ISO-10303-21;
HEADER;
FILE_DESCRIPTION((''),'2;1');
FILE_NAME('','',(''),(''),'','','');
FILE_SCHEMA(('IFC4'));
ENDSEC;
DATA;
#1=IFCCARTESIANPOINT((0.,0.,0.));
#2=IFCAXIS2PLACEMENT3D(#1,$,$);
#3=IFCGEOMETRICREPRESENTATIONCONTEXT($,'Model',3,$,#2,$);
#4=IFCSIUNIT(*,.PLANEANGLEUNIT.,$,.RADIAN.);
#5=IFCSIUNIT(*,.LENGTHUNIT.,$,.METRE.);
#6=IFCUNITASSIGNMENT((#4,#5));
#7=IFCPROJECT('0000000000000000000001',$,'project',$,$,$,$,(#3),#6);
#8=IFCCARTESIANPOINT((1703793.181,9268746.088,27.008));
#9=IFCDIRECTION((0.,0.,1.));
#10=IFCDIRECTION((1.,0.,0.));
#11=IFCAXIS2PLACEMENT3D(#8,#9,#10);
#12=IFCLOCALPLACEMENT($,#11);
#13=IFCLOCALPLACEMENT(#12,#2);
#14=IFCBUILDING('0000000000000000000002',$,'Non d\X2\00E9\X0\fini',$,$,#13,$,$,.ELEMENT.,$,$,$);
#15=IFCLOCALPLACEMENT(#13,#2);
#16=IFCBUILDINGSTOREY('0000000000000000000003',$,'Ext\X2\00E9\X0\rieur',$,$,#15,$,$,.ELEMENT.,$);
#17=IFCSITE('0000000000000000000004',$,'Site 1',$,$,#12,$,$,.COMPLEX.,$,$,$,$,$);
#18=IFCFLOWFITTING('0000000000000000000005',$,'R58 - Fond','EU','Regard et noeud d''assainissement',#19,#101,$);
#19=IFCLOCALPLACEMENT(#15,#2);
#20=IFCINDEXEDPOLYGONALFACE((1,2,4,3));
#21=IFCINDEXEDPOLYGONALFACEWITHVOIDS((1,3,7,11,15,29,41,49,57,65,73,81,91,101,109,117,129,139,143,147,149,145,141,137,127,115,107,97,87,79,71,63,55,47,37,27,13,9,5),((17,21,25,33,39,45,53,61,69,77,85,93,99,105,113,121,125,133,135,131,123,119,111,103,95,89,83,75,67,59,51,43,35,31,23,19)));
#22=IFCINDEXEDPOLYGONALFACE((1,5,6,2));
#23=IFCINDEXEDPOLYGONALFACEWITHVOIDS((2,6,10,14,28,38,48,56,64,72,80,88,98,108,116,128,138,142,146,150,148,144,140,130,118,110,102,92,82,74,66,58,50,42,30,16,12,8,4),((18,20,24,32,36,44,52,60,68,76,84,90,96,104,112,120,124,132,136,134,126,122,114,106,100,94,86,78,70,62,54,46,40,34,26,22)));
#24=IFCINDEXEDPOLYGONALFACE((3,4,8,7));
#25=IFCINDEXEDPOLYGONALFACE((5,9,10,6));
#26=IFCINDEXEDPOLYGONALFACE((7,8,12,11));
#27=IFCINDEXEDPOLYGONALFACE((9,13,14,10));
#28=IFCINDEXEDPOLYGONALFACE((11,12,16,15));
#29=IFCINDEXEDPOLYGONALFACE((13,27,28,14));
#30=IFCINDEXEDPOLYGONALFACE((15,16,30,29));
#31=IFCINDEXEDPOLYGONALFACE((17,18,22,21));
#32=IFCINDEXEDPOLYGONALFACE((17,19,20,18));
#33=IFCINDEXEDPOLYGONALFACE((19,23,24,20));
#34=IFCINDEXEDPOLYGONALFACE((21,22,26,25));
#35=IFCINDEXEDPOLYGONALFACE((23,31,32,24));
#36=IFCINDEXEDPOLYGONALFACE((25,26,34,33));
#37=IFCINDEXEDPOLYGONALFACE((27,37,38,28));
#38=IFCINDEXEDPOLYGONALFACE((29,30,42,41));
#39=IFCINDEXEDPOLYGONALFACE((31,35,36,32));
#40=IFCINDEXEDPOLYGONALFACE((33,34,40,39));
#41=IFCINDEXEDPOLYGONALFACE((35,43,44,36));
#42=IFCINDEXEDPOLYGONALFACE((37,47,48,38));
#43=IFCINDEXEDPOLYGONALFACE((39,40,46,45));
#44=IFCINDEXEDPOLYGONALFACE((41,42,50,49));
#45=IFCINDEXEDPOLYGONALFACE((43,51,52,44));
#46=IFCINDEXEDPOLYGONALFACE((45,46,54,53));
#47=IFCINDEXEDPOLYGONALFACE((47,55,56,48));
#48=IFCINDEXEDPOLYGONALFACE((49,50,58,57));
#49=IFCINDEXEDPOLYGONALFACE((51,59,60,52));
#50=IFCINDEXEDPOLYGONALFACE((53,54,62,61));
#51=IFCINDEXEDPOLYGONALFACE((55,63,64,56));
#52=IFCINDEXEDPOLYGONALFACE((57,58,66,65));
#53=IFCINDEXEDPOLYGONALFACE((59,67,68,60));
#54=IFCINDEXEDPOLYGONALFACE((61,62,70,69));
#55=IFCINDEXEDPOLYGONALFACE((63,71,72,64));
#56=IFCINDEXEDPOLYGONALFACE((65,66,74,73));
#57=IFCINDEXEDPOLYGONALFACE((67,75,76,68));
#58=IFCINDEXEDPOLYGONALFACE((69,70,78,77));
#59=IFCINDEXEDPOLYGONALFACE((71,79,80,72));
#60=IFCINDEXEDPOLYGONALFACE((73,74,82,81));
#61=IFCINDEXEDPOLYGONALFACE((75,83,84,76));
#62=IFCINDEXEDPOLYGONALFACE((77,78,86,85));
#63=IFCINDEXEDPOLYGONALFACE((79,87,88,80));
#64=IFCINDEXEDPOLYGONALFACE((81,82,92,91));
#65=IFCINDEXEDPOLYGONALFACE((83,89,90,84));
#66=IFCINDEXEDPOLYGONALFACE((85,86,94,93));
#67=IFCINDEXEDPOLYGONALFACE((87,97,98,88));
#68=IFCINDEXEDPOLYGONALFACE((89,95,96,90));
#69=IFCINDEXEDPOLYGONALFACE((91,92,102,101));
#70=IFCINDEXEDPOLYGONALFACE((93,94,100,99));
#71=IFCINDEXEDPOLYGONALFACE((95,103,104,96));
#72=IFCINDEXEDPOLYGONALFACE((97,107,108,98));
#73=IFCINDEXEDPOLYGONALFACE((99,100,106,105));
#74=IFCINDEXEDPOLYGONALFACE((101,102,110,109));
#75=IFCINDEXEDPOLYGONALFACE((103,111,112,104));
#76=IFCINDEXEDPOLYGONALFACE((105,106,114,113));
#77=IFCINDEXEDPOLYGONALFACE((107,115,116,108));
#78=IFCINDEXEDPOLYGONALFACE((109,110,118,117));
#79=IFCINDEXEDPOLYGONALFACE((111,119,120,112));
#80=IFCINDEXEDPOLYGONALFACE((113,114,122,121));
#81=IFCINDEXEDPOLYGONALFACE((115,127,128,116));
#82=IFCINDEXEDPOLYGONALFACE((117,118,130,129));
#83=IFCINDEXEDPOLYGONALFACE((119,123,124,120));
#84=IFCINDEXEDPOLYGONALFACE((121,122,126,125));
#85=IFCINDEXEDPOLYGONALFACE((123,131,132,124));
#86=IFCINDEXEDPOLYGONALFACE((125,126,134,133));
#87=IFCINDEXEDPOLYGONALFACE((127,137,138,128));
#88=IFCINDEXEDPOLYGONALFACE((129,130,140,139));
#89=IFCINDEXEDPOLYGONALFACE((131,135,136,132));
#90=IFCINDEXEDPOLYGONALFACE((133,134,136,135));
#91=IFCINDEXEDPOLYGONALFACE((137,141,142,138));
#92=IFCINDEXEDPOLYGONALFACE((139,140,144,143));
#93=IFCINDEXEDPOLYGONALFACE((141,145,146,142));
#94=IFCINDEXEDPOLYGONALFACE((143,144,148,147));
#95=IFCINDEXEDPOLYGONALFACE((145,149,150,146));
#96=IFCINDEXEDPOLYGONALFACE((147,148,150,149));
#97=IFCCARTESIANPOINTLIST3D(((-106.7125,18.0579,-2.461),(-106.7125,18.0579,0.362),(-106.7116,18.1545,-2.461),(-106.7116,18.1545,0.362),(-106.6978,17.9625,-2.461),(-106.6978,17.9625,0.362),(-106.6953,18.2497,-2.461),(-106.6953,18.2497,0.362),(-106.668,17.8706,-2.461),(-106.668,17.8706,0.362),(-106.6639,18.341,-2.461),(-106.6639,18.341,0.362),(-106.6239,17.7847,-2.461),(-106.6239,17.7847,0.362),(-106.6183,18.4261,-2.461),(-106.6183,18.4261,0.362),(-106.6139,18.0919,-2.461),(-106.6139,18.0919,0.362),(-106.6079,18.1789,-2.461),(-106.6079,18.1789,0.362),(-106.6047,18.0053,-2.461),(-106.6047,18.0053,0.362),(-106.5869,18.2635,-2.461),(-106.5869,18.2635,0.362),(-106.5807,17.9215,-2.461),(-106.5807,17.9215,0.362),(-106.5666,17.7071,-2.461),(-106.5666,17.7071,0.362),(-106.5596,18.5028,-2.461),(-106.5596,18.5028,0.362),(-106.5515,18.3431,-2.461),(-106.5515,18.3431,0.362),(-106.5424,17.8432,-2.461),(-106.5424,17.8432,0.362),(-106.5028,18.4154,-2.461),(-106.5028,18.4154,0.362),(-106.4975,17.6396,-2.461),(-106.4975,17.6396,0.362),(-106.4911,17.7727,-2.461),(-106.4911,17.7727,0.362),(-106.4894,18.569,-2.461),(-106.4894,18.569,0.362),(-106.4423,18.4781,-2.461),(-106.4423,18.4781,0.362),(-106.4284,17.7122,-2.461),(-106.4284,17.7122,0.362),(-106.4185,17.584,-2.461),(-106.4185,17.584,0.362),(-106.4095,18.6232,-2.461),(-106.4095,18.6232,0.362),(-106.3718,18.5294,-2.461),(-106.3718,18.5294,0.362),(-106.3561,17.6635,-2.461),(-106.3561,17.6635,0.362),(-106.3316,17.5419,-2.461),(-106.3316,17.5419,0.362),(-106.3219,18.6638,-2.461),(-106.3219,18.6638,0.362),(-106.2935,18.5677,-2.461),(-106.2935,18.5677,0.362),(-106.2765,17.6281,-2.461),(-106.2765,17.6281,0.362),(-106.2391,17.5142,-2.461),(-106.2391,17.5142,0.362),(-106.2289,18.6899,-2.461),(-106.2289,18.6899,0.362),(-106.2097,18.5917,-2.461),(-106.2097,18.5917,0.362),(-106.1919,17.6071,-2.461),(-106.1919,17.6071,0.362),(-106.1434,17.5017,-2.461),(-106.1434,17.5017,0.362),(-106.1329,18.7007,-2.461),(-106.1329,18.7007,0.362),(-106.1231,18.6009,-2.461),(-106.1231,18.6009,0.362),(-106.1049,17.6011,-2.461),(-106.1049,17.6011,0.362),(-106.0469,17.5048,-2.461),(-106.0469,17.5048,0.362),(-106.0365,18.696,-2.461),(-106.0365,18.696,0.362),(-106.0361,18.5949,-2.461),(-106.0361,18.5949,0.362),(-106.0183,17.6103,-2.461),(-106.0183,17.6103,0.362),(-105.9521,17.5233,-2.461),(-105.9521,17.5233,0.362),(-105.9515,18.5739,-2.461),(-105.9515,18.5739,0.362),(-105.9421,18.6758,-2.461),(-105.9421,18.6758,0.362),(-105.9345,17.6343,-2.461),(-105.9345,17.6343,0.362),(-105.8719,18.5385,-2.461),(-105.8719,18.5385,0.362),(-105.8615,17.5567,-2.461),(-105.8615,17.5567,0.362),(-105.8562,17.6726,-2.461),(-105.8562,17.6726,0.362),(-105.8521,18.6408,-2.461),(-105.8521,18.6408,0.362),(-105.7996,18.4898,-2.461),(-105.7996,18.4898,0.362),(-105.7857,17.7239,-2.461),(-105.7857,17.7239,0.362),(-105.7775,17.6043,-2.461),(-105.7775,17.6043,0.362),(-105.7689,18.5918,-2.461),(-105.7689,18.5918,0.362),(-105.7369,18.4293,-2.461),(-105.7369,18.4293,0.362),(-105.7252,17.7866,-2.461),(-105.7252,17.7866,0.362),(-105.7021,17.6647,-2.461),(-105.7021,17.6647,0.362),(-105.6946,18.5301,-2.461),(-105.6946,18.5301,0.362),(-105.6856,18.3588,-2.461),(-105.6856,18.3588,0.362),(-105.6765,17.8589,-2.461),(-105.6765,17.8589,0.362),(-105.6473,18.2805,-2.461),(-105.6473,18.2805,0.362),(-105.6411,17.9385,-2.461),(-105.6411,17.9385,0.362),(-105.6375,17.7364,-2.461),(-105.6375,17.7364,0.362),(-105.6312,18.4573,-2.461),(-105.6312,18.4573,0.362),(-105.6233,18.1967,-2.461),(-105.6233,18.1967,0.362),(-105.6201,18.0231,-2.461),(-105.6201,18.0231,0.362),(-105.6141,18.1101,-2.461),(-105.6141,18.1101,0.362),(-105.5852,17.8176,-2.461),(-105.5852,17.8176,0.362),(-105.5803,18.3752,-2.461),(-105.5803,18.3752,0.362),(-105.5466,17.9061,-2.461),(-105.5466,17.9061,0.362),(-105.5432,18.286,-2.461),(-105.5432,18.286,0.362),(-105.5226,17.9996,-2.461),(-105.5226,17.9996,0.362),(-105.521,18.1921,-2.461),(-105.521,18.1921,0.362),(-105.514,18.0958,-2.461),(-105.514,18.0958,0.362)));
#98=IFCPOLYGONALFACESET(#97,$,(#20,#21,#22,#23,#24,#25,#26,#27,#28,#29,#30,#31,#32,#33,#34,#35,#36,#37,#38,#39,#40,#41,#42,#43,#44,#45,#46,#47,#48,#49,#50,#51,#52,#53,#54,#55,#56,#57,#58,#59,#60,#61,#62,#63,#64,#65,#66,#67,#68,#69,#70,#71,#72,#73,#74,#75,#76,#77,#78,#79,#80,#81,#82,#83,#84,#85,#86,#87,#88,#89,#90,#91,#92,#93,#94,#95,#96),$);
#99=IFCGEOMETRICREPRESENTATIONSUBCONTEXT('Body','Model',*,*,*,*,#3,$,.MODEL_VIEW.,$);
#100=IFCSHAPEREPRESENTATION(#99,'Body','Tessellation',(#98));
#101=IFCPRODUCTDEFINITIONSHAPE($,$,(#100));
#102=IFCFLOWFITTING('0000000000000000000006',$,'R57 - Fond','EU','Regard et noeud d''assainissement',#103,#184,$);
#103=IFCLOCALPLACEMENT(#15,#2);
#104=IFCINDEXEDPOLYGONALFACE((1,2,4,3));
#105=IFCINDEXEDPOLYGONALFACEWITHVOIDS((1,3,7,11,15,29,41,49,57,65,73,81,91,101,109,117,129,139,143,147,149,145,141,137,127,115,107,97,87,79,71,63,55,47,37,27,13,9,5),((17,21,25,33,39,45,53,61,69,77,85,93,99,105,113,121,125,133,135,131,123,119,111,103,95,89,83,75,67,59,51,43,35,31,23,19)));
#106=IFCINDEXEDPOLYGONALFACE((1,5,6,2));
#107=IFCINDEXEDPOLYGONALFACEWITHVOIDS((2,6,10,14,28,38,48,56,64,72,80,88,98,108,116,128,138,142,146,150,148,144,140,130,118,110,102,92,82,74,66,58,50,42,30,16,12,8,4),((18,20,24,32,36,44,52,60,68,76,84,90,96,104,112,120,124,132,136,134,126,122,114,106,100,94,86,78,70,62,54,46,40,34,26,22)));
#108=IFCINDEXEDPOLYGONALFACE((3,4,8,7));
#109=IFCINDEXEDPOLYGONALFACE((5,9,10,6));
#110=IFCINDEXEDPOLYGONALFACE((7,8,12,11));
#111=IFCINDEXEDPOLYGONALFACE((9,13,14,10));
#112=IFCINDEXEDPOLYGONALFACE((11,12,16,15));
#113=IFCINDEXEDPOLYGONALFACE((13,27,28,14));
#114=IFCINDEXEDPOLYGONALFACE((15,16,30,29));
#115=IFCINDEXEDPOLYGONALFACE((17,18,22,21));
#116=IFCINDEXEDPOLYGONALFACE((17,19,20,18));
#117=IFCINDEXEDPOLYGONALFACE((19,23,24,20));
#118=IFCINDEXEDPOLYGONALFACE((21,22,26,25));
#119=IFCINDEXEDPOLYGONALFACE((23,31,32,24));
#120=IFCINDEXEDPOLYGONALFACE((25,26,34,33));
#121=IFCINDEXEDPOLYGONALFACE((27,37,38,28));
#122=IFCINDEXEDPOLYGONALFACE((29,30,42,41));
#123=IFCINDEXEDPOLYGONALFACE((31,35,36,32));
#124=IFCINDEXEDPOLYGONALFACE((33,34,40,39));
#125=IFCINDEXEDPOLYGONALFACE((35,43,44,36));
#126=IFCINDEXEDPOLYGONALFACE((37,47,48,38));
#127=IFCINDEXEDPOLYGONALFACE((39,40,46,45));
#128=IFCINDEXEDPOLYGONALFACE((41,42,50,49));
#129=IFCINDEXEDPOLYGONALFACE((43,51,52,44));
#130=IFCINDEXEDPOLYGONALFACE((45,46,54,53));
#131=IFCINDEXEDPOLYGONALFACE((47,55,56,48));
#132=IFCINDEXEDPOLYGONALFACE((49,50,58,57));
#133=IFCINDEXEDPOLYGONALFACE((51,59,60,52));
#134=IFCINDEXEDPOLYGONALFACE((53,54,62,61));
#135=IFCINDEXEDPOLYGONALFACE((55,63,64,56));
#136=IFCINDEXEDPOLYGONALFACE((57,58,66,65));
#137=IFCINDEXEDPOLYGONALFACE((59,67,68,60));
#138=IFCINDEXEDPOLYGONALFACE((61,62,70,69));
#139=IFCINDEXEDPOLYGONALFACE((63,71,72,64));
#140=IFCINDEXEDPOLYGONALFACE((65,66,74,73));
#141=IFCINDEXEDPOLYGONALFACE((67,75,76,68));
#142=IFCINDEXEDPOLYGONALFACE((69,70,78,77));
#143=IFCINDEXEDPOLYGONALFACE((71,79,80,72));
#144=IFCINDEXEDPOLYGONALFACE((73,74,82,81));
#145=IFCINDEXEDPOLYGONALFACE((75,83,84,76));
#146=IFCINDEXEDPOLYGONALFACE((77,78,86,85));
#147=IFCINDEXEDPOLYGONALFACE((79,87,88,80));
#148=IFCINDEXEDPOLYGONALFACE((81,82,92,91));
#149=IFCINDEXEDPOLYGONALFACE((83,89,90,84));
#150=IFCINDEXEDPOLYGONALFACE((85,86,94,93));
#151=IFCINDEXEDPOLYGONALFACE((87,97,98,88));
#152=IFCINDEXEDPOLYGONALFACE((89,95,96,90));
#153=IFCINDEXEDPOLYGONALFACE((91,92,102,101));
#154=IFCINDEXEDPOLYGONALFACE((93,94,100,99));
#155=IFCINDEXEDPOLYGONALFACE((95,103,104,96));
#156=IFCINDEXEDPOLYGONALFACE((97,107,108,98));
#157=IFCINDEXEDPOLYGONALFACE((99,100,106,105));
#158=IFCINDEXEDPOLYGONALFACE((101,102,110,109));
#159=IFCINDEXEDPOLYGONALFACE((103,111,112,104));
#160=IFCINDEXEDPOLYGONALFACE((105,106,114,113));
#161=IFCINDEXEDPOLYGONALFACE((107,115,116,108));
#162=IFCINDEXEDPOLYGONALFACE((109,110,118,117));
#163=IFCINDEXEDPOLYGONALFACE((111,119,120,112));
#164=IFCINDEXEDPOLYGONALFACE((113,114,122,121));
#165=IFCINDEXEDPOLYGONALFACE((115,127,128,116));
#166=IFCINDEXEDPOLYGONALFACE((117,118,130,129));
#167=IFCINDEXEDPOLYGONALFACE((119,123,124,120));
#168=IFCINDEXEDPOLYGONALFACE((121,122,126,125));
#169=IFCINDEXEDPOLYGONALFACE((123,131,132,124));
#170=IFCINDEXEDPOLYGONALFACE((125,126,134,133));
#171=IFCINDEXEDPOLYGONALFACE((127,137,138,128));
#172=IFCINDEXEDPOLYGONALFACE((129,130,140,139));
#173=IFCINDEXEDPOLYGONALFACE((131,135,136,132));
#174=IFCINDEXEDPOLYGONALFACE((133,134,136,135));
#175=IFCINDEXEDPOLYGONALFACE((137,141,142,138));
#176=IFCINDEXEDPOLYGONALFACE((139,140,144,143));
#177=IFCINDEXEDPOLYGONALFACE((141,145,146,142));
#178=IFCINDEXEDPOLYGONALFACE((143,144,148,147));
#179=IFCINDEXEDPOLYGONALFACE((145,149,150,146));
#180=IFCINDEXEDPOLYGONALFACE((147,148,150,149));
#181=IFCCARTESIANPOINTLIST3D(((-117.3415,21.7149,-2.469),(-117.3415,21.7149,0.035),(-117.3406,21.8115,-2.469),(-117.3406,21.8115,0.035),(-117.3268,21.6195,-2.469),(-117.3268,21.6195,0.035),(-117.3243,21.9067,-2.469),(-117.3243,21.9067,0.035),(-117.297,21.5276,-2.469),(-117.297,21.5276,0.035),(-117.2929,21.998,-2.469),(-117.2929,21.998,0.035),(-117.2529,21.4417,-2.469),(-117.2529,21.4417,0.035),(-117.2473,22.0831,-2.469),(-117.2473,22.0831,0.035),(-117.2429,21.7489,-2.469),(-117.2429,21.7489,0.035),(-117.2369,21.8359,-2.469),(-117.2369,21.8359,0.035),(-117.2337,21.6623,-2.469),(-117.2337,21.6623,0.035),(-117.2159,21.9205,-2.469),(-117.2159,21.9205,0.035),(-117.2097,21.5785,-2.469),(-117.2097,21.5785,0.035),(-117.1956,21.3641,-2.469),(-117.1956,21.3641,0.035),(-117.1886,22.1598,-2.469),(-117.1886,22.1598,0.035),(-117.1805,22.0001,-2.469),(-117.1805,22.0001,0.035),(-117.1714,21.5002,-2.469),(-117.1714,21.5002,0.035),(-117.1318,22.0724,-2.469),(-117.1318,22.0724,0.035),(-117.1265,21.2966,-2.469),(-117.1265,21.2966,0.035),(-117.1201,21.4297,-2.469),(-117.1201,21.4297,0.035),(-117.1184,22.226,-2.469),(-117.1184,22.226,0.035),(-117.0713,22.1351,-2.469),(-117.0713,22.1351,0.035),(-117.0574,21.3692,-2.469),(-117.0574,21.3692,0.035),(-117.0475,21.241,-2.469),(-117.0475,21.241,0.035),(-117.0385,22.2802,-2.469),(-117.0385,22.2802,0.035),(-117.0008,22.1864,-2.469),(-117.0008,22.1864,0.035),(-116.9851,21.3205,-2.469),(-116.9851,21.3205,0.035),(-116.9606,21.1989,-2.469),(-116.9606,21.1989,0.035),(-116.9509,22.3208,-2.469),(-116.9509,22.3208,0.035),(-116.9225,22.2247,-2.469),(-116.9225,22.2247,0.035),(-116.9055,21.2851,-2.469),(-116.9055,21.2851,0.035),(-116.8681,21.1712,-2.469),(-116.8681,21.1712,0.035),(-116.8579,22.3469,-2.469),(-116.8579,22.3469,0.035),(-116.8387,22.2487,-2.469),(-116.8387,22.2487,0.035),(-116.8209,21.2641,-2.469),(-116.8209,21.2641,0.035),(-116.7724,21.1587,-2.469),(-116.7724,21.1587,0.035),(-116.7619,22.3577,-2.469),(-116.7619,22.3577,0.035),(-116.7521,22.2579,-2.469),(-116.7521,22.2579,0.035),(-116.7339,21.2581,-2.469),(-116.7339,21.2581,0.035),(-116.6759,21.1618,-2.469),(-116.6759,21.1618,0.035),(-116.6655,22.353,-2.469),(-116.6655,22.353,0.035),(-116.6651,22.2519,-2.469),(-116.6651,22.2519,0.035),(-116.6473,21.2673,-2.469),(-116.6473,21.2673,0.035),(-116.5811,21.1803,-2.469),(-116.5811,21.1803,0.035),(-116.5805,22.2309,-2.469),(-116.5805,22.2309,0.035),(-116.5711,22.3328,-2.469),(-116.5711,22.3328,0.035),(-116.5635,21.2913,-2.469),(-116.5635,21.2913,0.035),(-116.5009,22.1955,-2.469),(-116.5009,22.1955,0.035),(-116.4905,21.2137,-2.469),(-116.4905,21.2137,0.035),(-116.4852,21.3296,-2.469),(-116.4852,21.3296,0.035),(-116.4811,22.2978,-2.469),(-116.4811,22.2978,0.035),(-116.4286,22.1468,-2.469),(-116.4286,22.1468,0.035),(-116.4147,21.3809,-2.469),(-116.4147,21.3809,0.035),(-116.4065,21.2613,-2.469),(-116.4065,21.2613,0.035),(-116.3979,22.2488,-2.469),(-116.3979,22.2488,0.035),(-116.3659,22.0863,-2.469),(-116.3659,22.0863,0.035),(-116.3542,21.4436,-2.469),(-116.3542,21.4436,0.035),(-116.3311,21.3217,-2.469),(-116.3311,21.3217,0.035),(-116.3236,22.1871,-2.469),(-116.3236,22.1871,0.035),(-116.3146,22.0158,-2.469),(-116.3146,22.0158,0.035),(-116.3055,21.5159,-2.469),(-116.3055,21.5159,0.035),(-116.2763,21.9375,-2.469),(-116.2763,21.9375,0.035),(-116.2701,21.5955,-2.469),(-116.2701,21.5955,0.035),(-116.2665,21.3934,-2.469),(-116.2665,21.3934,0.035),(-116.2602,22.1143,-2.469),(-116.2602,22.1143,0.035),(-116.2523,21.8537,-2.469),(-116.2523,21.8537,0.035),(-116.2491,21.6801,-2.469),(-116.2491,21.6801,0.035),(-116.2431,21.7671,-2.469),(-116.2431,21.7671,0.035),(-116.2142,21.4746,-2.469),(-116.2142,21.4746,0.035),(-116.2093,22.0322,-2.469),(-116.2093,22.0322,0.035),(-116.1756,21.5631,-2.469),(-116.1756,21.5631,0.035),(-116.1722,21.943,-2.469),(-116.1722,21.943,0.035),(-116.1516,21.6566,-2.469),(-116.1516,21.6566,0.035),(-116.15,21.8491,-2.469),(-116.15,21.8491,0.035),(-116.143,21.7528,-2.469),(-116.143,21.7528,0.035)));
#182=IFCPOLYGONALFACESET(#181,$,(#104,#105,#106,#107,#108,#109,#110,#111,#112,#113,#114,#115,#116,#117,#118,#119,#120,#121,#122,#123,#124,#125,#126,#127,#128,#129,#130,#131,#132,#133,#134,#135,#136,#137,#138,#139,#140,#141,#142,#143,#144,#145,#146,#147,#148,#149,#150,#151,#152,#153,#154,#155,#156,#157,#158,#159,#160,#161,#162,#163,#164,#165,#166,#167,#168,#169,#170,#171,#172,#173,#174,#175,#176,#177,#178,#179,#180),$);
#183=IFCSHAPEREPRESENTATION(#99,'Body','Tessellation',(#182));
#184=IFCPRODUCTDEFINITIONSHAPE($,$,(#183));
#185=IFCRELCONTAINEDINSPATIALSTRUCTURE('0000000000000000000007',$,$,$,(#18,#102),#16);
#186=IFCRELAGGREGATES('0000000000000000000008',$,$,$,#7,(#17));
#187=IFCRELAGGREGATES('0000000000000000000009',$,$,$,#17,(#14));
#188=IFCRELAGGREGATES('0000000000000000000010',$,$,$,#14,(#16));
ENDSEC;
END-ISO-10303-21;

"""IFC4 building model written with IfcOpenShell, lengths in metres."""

from ifc_helpers import new_model, si_unit, frame, origin, origin_2d, place, context, subcontext, project, spatial, hollow_circle, extrude, element, save


model = new_model("IFC4")

# Units and contexts
model_context = context("Model", 3, world=origin())
body_context = subcontext(model_context, "Body", "Model", "MODEL_VIEW")
ifc_project = project(units=[si_unit("PLANEANGLEUNIT", "RADIAN"), si_unit("LENGTHUNIT", "METRE")], contexts=[model_context])

# Site, building, storey
site_placement = place(None, frame((1703793.181, 9268746.088, 27.008), z_axis=(0.0, 0.0, 1.0), x_axis=(1.0, 0.0, 0.0)))
site = spatial("IfcSite", under=ifc_project, at=site_placement, Name="Site 1", CompositionType="COMPLEX")
building_placement = place(site_placement, origin())
building = spatial("IfcBuilding", under=site, at=building_placement, Name="Non défini", CompositionType="ELEMENT")
storey_placement = place(building_placement, origin())
storey = spatial("IfcBuildingStorey", under=building, at=storey_placement, Name="Extérieur", CompositionType="ELEMENT")

# Flow fittings
flow_fitting_1_placement = place(storey_placement, origin())
element("IfcFlowFitting", 1, at=flow_fitting_1_placement, inside=storey, Name="R58 - Fond", Description="EU", ObjectType="Regard et noeud d'assainissement", context=body_context, shape_type="SweptSolid", body=[
    extrude(hollow_circle(Radius=0.6, WallThickness=0.1, at=origin_2d()), frame((-106.114, 18.101, -2.461), z_axis=(0.0, 0.0, 1.0), x_axis=(0.946, -0.325, 0.0)), (0.0, 0.0, 1.0), 2.823),
])
flow_fitting_2_placement = place(storey_placement, origin())
element("IfcFlowFitting", 2, at=flow_fitting_2_placement, inside=storey, Name="R57 - Fond", Description="EU", ObjectType="Regard et noeud d'assainissement", context=body_context, shape_type="SweptSolid", body=[
    extrude(hollow_circle(Radius=0.6, WallThickness=0.1, at=origin_2d()), frame((-116.743, 21.758, -2.469), z_axis=(0.0, 0.0, 1.0), x_axis=(0.946, -0.325, 0.0)), (0.0, 0.0, 1.0), 2.504),
])

save(model, "model.ifc")
